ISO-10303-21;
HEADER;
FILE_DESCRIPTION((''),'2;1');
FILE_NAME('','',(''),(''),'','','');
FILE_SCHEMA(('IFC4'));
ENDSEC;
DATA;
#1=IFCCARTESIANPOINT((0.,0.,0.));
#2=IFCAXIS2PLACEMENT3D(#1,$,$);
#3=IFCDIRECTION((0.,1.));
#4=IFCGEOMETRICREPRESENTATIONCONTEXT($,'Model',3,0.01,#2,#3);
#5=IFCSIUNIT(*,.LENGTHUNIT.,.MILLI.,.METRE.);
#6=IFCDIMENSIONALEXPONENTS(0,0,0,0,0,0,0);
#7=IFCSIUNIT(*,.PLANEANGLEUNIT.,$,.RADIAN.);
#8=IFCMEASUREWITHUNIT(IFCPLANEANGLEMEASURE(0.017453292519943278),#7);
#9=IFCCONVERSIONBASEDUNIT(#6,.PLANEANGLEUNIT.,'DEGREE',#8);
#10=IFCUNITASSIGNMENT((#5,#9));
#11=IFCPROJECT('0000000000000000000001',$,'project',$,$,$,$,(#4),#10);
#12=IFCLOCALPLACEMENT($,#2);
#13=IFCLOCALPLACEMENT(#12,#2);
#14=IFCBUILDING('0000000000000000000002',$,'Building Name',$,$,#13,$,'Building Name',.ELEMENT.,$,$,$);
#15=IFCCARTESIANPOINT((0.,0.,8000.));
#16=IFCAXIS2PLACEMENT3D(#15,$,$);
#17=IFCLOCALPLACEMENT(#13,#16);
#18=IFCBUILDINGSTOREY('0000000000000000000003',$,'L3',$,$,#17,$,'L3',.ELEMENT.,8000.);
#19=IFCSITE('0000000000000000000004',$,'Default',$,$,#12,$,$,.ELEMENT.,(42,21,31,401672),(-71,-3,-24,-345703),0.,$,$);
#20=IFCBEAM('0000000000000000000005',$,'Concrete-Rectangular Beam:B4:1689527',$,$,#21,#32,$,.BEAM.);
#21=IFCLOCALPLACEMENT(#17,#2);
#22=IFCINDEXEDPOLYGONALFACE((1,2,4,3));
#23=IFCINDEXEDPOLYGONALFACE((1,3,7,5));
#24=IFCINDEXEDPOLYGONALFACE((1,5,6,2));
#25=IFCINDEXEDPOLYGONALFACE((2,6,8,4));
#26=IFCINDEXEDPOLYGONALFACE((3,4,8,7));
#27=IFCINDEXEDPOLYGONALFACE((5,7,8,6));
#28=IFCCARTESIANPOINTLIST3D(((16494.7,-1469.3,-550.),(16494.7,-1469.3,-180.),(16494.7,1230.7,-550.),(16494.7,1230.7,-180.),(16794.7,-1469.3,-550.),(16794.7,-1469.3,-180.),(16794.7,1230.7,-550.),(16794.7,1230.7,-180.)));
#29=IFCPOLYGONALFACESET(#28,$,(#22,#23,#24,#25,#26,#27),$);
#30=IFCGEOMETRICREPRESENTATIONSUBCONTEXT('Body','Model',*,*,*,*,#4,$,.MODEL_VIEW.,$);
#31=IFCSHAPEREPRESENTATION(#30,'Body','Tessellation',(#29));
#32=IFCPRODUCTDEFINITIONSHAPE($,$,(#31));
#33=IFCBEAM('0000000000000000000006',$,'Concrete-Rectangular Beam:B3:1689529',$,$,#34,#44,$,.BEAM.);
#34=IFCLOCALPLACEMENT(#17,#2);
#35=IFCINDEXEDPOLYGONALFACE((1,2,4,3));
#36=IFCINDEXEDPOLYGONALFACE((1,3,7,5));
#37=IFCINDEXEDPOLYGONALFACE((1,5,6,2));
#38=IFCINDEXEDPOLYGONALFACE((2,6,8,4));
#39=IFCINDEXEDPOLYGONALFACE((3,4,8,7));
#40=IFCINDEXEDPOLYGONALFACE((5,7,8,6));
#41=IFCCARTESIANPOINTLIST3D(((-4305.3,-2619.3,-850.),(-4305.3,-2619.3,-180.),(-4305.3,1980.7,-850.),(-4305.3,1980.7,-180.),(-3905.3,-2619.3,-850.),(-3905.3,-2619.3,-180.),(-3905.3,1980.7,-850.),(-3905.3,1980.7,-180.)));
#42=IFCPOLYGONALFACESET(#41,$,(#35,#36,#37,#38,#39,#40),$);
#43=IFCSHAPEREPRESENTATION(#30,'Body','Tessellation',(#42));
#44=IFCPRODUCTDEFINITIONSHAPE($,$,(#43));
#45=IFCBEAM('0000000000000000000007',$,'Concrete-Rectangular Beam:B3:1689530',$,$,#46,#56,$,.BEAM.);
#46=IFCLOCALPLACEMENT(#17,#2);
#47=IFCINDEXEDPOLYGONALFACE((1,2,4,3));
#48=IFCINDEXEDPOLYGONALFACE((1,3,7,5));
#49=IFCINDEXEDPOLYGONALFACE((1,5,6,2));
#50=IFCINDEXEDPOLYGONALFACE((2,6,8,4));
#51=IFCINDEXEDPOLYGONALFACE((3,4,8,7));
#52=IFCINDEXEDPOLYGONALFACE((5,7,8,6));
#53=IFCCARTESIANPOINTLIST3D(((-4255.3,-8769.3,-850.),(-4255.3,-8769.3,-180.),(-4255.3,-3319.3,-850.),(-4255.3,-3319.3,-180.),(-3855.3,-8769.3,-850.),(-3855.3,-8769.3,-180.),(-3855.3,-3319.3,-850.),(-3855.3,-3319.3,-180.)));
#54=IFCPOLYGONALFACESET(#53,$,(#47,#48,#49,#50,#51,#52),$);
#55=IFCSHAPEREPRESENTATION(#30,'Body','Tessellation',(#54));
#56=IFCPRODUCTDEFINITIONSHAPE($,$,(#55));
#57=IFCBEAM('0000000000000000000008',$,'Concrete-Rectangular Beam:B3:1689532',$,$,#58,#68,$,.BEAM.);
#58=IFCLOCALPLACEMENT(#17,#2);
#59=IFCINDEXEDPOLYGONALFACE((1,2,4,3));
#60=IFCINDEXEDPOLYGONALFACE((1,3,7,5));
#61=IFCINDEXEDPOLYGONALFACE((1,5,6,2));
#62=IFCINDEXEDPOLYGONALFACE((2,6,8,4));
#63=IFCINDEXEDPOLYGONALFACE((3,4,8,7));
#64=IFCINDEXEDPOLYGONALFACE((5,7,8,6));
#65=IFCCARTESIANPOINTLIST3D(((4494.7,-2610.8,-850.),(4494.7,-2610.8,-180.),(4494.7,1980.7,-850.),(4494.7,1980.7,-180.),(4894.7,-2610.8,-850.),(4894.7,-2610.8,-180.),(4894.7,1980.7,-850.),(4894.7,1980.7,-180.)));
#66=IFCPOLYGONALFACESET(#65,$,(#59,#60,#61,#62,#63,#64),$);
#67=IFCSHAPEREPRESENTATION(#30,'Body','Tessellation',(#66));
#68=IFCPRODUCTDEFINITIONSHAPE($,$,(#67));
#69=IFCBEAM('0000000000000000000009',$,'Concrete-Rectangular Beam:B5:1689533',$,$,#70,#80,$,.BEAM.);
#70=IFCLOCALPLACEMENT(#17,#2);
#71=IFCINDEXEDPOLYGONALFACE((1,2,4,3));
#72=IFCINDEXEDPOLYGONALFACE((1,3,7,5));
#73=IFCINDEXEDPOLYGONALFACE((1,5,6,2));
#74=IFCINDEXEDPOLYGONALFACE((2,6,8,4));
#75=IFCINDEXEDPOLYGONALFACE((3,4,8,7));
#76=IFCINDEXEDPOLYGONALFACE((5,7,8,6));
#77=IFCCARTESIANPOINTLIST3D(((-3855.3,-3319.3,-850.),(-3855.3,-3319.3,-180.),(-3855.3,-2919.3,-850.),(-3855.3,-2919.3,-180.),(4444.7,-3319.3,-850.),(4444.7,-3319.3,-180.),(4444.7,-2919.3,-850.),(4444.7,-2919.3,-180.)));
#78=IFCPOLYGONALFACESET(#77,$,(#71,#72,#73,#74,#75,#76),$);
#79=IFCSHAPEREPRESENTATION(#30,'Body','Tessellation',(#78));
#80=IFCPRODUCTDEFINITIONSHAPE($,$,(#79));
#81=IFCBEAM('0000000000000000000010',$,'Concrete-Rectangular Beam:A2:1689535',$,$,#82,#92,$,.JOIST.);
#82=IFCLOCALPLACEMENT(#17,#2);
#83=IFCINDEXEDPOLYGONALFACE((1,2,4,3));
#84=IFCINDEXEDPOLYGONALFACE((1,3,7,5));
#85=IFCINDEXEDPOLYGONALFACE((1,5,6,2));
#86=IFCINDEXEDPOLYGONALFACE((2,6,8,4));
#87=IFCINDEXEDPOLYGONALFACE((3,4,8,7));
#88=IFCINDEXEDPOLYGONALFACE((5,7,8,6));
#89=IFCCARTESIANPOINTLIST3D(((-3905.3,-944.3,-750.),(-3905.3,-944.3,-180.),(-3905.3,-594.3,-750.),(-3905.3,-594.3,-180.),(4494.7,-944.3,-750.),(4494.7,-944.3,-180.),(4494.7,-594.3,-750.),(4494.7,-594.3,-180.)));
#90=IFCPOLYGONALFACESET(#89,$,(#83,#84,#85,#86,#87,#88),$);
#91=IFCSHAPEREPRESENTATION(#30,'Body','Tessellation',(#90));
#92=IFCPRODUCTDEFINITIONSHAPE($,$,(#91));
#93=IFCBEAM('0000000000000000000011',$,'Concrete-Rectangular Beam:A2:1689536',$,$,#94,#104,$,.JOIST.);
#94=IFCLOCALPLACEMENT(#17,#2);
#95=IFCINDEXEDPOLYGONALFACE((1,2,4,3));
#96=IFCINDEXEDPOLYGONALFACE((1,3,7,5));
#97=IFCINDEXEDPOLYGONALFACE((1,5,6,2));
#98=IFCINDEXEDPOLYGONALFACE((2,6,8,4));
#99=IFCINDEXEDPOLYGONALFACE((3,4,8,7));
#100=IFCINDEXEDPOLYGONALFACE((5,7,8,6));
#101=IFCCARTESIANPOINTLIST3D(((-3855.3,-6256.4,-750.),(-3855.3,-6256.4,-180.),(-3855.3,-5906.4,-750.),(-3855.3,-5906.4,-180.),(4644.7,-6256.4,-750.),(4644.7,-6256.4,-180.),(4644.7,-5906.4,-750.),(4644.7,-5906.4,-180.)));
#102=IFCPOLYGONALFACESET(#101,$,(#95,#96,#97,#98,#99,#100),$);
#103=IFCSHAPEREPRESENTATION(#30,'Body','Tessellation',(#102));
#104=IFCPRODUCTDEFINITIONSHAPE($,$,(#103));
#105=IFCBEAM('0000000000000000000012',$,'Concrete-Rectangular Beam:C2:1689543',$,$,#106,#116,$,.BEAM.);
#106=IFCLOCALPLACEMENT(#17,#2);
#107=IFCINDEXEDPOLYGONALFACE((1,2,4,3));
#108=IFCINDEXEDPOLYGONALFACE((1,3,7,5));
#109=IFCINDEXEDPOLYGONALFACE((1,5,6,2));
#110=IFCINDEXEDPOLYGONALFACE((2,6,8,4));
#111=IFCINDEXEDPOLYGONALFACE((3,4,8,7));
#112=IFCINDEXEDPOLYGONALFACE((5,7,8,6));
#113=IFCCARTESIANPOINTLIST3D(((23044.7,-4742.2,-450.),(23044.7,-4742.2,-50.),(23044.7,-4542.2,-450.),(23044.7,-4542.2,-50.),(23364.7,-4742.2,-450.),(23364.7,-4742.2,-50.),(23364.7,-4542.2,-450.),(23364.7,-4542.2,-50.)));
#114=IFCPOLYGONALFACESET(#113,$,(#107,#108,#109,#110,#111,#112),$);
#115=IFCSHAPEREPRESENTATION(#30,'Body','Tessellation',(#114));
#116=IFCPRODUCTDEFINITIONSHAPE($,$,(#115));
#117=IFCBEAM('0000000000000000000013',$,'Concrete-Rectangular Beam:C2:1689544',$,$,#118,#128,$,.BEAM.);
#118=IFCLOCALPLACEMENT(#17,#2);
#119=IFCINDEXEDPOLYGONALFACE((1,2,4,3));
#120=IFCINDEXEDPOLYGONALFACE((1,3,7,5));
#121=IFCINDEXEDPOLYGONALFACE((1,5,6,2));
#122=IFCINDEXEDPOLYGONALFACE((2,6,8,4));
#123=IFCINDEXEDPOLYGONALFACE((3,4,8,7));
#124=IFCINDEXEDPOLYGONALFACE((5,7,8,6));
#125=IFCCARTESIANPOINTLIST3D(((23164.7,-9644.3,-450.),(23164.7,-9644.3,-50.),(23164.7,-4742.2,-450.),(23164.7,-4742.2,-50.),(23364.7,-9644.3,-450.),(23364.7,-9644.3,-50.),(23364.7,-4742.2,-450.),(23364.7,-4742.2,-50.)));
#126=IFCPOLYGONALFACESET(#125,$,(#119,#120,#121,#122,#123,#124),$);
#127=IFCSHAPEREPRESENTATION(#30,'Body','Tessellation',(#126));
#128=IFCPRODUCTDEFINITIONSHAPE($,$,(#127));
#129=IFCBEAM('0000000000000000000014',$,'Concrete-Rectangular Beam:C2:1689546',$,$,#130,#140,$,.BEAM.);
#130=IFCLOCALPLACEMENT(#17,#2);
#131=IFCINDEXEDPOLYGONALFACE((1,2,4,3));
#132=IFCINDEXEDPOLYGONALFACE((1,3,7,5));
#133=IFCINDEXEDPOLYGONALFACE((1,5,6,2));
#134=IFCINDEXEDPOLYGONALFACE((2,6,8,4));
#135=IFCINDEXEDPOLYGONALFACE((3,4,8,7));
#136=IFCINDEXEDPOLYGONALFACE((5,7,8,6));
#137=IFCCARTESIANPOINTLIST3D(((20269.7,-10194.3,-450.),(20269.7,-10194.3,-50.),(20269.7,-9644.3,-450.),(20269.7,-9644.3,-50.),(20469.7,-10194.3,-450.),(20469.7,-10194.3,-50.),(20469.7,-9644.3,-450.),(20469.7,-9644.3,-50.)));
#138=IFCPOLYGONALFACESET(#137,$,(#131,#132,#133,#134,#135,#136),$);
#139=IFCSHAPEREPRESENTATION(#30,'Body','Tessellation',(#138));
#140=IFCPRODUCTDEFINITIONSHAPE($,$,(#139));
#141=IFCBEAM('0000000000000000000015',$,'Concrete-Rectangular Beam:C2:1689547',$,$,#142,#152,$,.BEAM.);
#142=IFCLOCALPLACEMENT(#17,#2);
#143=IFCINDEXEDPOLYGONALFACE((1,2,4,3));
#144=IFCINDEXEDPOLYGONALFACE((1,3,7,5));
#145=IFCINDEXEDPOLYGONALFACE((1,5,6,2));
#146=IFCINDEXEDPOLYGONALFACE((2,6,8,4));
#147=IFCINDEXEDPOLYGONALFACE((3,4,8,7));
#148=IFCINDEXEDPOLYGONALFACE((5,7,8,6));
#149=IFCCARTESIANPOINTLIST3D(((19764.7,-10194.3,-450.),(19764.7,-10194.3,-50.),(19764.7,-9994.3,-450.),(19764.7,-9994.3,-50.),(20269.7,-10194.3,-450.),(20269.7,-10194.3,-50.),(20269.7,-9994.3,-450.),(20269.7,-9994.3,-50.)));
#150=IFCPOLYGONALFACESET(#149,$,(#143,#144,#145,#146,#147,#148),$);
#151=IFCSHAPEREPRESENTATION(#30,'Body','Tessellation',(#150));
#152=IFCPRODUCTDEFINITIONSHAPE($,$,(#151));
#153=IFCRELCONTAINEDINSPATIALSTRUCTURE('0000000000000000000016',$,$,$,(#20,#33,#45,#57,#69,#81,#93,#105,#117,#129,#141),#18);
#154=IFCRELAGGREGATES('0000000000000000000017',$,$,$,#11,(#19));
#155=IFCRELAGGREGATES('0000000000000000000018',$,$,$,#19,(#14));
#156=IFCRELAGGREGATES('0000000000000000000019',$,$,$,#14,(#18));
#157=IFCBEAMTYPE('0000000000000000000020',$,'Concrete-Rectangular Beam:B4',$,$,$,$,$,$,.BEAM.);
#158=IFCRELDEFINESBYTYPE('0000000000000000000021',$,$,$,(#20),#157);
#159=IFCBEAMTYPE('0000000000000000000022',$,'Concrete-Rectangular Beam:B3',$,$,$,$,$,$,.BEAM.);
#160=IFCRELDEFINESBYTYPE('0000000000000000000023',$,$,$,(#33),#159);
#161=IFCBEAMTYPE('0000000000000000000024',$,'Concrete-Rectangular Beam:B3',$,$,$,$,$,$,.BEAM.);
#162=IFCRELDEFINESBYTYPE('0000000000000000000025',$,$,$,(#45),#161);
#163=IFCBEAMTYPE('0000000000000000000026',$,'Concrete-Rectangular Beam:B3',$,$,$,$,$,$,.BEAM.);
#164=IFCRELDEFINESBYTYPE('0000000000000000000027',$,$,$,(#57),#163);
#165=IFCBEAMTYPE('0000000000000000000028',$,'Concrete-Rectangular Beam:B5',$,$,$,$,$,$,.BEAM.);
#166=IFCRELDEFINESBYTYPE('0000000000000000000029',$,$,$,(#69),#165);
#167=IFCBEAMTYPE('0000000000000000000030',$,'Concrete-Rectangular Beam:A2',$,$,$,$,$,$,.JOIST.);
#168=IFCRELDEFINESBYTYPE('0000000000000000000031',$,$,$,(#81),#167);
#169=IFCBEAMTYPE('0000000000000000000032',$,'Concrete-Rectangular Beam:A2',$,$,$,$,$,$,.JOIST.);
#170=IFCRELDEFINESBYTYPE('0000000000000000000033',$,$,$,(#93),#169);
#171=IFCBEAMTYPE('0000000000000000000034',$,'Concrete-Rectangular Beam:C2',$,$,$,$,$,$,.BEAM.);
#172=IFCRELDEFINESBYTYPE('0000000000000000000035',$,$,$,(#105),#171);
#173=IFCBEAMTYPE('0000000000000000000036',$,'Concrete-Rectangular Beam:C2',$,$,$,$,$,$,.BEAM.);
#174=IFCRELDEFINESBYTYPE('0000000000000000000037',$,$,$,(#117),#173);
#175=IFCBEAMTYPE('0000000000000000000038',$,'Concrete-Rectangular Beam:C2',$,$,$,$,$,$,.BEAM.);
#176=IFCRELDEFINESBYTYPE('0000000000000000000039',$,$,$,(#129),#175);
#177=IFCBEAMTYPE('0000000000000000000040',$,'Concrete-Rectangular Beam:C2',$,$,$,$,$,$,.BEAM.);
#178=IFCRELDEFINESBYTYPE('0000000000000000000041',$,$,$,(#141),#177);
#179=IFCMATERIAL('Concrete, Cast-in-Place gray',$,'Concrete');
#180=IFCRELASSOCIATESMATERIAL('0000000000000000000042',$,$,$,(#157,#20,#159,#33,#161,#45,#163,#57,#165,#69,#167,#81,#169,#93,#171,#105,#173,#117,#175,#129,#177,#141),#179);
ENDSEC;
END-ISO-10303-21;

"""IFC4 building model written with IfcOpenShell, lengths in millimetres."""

from ifc_helpers import new_model, entity, si_unit, converted_unit, direction, frame, origin, place, context, subcontext, project, spatial, indexed_curve, outline, extrude, source, transform, mapped, material, type_object, type_shapes, element, save


model = new_model("IFC4")

# Units and contexts
model_context = context("Model", 3, precision=0.01, world=origin(), true_north=direction((0.0, 1.0)))
body_context = subcontext(model_context, "Body", "Model", "MODEL_VIEW")
ifc_project = project(units=[si_unit("LENGTHUNIT", "METRE", prefix="MILLI"), converted_unit("PLANEANGLEUNIT", "DEGREE", entity("IfcPlaneAngleMeasure", 0.017453292519943278), si_unit("PLANEANGLEUNIT", "RADIAN"), dimensions=[0, 0, 0, 0, 0, 0, 0])], contexts=[model_context])

# Site, building, storey
site_placement = place(None, origin())
site = spatial("IfcSite", under=ifc_project, at=site_placement, Name="Default", CompositionType="ELEMENT", RefLatitude=(42, 21, 31, 401672), RefLongitude=(-71, -3, -24, -345703), RefElevation=0.0)
building_placement = place(site_placement, origin())
building = spatial("IfcBuilding", under=site, at=building_placement, Name="Building Name", LongName="Building Name", CompositionType="ELEMENT")
storey_placement = place(building_placement, frame((0.0, 0.0, 8000.0)))
storey = spatial("IfcBuildingStorey", under=building, at=storey_placement, Name="L3", LongName="L3", CompositionType="ELEMENT", Elevation=8000.0)

# Beams
ifc_material = material(Name="Concrete, Cast-in-Place gray", Category="Concrete")
beam_type_1 = type_object("IfcBeamType", Name="Concrete-Rectangular Beam:B4", PredefinedType="BEAM", material=ifc_material)
shared_shape_1 = source(origin(), body_context, "Body", "SweptSolid", [
    extrude(outline(indexed_curve([(-150.0, -185.0), (150.0, -185.0), (150.0, 185.0), (-150.0, 185.0), (-150.0, -185.0)], self_intersect=False)), frame((16644.7, 1230.7, 7635.0), z_axis=(0.0, -1.0, 0.0), x_axis=(-1.0, 0.0, 0.0)), (0.0, 0.0, 1.0), 2700.0),
])
type_shapes(beam_type_1, [shared_shape_1])
beam_1_placement = place(storey_placement, frame((0.0, 0.0, -8000.0)))
element("IfcBeam", 1, at=beam_1_placement, inside=storey, type_object=beam_type_1, material=ifc_material, Name="Concrete-Rectangular Beam:B4:1689527", PredefinedType="BEAM", context=body_context, shape_type="MappedRepresentation", body=[
    mapped(shared_shape_1, transform((0.0, 0.0, 0.0), scale=1.0)),
])
beam_type_2 = type_object("IfcBeamType", Name="Concrete-Rectangular Beam:B3", PredefinedType="BEAM", material=ifc_material)
shared_shape_2 = source(origin(), body_context, "Body", "SweptSolid", [
    extrude(outline(indexed_curve([(-200.0, -335.0), (200.0, -335.0), (200.0, 335.0), (-200.0, 335.0), (-200.0, -335.0)], self_intersect=False)), frame((-4105.3, 1980.7, 7485.0), z_axis=(0.0, -1.0, 0.0), x_axis=(-1.0, 0.0, 0.0)), (0.0, 0.0, 1.0), 4600.0),
])
type_shapes(beam_type_2, [shared_shape_2])
beam_2_placement = place(storey_placement, frame((0.0, 0.0, -8000.0)))
element("IfcBeam", 2, at=beam_2_placement, inside=storey, type_object=beam_type_2, material=ifc_material, Name="Concrete-Rectangular Beam:B3:1689529", PredefinedType="BEAM", context=body_context, shape_type="MappedRepresentation", body=[
    mapped(shared_shape_2, transform((0.0, 0.0, 0.0), scale=1.0)),
])
beam_type_3 = type_object("IfcBeamType", Name="Concrete-Rectangular Beam:B3", PredefinedType="BEAM", material=ifc_material)
shared_shape_3 = source(origin(), body_context, "Body", "SweptSolid", [
    extrude(outline(indexed_curve([(-200.0, -335.0), (200.0, -335.0), (200.0, 335.0), (-200.0, 335.0), (-200.0, -335.0)], self_intersect=False)), frame((-4055.3, -3319.3, 7485.0), z_axis=(0.0, -1.0, 0.0), x_axis=(-1.0, 0.0, 0.0)), (0.0, 0.0, 1.0), 5450.0),
])
type_shapes(beam_type_3, [shared_shape_3])
beam_3_placement = place(storey_placement, frame((0.0, 0.0, -8000.0)))
element("IfcBeam", 3, at=beam_3_placement, inside=storey, type_object=beam_type_3, material=ifc_material, Name="Concrete-Rectangular Beam:B3:1689530", PredefinedType="BEAM", context=body_context, shape_type="MappedRepresentation", body=[
    mapped(shared_shape_3, transform((0.0, 0.0, 0.0), scale=1.0)),
])
beam_type_4 = type_object("IfcBeamType", Name="Concrete-Rectangular Beam:B3", PredefinedType="BEAM", material=ifc_material)
shared_shape_4 = source(origin(), body_context, "Body", "SweptSolid", [
    extrude(outline(indexed_curve([(-200.0, -335.0), (200.0, -335.0), (200.0, 335.0), (-200.0, 335.0), (-200.0, -335.0)], self_intersect=False)), frame((4694.7, -2610.8, 7485.0), z_axis=(0.0, 1.0, 0.0), x_axis=(-1.0, 0.0, 0.0)), (0.0, 0.0, 1.0), 4591.4),
])
type_shapes(beam_type_4, [shared_shape_4])
beam_4_placement = place(storey_placement, frame((0.0, 0.0, -8000.0)))
element("IfcBeam", 4, at=beam_4_placement, inside=storey, type_object=beam_type_4, material=ifc_material, Name="Concrete-Rectangular Beam:B3:1689532", PredefinedType="BEAM", context=body_context, shape_type="MappedRepresentation", body=[
    mapped(shared_shape_4, transform((0.0, 0.0, 0.0), scale=1.0)),
])
beam_type_5 = type_object("IfcBeamType", Name="Concrete-Rectangular Beam:B5", PredefinedType="BEAM", material=ifc_material)
shared_shape_5 = source(origin(), body_context, "Body", "SweptSolid", [
    extrude(outline(indexed_curve([(-335.0, -200.0), (335.0, -200.0), (335.0, 200.0), (-335.0, 200.0), (-335.0, -200.0)], self_intersect=False)), frame((-3855.3, -3119.3, 7485.0), z_axis=(1.0, 0.0, 0.0), x_axis=(0.0, 0.0, -1.0)), (0.0, 0.0, 1.0), 8300.0),
])
type_shapes(beam_type_5, [shared_shape_5])
beam_5_placement = place(storey_placement, frame((0.0, 0.0, -8000.0)))
element("IfcBeam", 5, at=beam_5_placement, inside=storey, type_object=beam_type_5, material=ifc_material, Name="Concrete-Rectangular Beam:B5:1689533", PredefinedType="BEAM", context=body_context, shape_type="MappedRepresentation", body=[
    mapped(shared_shape_5, transform((0.0, 0.0, 0.0), scale=1.0)),
])
beam_type_6 = type_object("IfcBeamType", Name="Concrete-Rectangular Beam:A2", PredefinedType="JOIST", material=ifc_material)
shared_shape_6 = source(origin(), body_context, "Body", "SweptSolid", [
    extrude(outline(indexed_curve([(-285.0, -175.0), (285.0, -175.0), (285.0, 175.0), (-285.0, 175.0), (-285.0, -175.0)], self_intersect=False)), frame((-3905.3, -769.3, 7535.0), z_axis=(1.0, 0.0, 0.0), x_axis=(0.0, 0.0, -1.0)), (0.0, 0.0, 1.0), 8400.0),
])
type_shapes(beam_type_6, [shared_shape_6])
beam_6_placement = place(storey_placement, frame((0.0, 0.0, -8000.0)))
element("IfcBeam", 6, at=beam_6_placement, inside=storey, type_object=beam_type_6, material=ifc_material, Name="Concrete-Rectangular Beam:A2:1689535", PredefinedType="JOIST", context=body_context, shape_type="MappedRepresentation", body=[
    mapped(shared_shape_6, transform((0.0, 0.0, 0.0), scale=1.0)),
])
beam_type_7 = type_object("IfcBeamType", Name="Concrete-Rectangular Beam:A2", PredefinedType="JOIST", material=ifc_material)
shared_shape_7 = source(origin(), body_context, "Body", "SweptSolid", [
    extrude(outline(indexed_curve([(-285.0, -175.0), (285.0, -175.0), (285.0, 175.0), (-285.0, 175.0), (-285.0, -175.0)], self_intersect=False)), frame((-3855.3, -6081.4, 7535.0), z_axis=(1.0, 0.0, 0.0), x_axis=(0.0, 0.0, -1.0)), (0.0, 0.0, 1.0), 8500.0),
])
type_shapes(beam_type_7, [shared_shape_7])
beam_7_placement = place(storey_placement, frame((0.0, 0.0, -8000.0)))
element("IfcBeam", 7, at=beam_7_placement, inside=storey, type_object=beam_type_7, material=ifc_material, Name="Concrete-Rectangular Beam:A2:1689536", PredefinedType="JOIST", context=body_context, shape_type="MappedRepresentation", body=[
    mapped(shared_shape_7, transform((0.0, 0.0, 0.0), scale=1.0)),
])
beam_type_8 = type_object("IfcBeamType", Name="Concrete-Rectangular Beam:C2", PredefinedType="BEAM", material=ifc_material)
shared_shape_8 = source(origin(), body_context, "Body", "SweptSolid", [
    extrude(outline(indexed_curve([(-200.0, -100.0), (200.0, -100.0), (200.0, 100.0), (-200.0, 100.0), (-200.0, -100.0)], self_intersect=False)), frame((23044.7, -4642.2, 7750.0), z_axis=(1.0, 0.0, 0.0), x_axis=(0.0, 0.0, -1.0)), (0.0, 0.0, 1.0), 320.0),
])
type_shapes(beam_type_8, [shared_shape_8])
beam_8_placement = place(storey_placement, frame((0.0, 0.0, -8000.0)))
element("IfcBeam", 8, at=beam_8_placement, inside=storey, type_object=beam_type_8, material=ifc_material, Name="Concrete-Rectangular Beam:C2:1689543", PredefinedType="BEAM", context=body_context, shape_type="MappedRepresentation", body=[
    mapped(shared_shape_8, transform((0.0, 0.0, 0.0), scale=1.0)),
])
beam_type_9 = type_object("IfcBeamType", Name="Concrete-Rectangular Beam:C2", PredefinedType="BEAM", material=ifc_material)
shared_shape_9 = source(origin(), body_context, "Body", "SweptSolid", [
    extrude(outline(indexed_curve([(-100.0, -200.0), (100.0, -200.0), (100.0, 200.0), (-100.0, 200.0), (-100.0, -200.0)], self_intersect=False)), frame((23264.7, -4742.2, 7750.0), z_axis=(0.0, -1.0, 0.0), x_axis=(-1.0, 0.0, 0.0)), (0.0, 0.0, 1.0), 4902.1),
])
type_shapes(beam_type_9, [shared_shape_9])
beam_9_placement = place(storey_placement, frame((0.0, 0.0, -8000.0)))
element("IfcBeam", 9, at=beam_9_placement, inside=storey, type_object=beam_type_9, material=ifc_material, Name="Concrete-Rectangular Beam:C2:1689544", PredefinedType="BEAM", context=body_context, shape_type="MappedRepresentation", body=[
    mapped(shared_shape_9, transform((0.0, 0.0, 0.0), scale=1.0)),
])
beam_type_10 = type_object("IfcBeamType", Name="Concrete-Rectangular Beam:C2", PredefinedType="BEAM", material=ifc_material)
shared_shape_10 = source(origin(), body_context, "Body", "SweptSolid", [
    extrude(outline(indexed_curve([(-100.0, -200.0), (100.0, -200.0), (100.0, 200.0), (-100.0, 200.0), (-100.0, -200.0)], self_intersect=False)), frame((20369.7, -9644.3, 7750.0), z_axis=(0.0, -1.0, 0.0), x_axis=(-1.0, 0.0, 0.0)), (0.0, 0.0, 1.0), 550.0),
])
type_shapes(beam_type_10, [shared_shape_10])
beam_10_placement = place(storey_placement, frame((0.0, 0.0, -8000.0)))
element("IfcBeam", 10, at=beam_10_placement, inside=storey, type_object=beam_type_10, material=ifc_material, Name="Concrete-Rectangular Beam:C2:1689546", PredefinedType="BEAM", context=body_context, shape_type="MappedRepresentation", body=[
    mapped(shared_shape_10, transform((0.0, 0.0, 0.0), scale=1.0)),
])
beam_type_11 = type_object("IfcBeamType", Name="Concrete-Rectangular Beam:C2", PredefinedType="BEAM", material=ifc_material)
shared_shape_11 = source(origin(), body_context, "Body", "SweptSolid", [
    extrude(outline(indexed_curve([(-200.0, -100.0), (200.0, -100.0), (200.0, 100.0), (-200.0, 100.0), (-200.0, -100.0)], self_intersect=False)), frame((20269.7, -10094.3, 7750.0), z_axis=(-1.0, 0.0, 0.0), x_axis=(0.0, 0.0, -1.0)), (0.0, 0.0, 1.0), 505.0),
])
type_shapes(beam_type_11, [shared_shape_11])
beam_11_placement = place(storey_placement, frame((0.0, 0.0, -8000.0)))
element("IfcBeam", 11, at=beam_11_placement, inside=storey, type_object=beam_type_11, material=ifc_material, Name="Concrete-Rectangular Beam:C2:1689547", PredefinedType="BEAM", context=body_context, shape_type="MappedRepresentation", body=[
    mapped(shared_shape_11, transform((0.0, 0.0, 0.0), scale=1.0)),
])

save(model, "model.ifc")
